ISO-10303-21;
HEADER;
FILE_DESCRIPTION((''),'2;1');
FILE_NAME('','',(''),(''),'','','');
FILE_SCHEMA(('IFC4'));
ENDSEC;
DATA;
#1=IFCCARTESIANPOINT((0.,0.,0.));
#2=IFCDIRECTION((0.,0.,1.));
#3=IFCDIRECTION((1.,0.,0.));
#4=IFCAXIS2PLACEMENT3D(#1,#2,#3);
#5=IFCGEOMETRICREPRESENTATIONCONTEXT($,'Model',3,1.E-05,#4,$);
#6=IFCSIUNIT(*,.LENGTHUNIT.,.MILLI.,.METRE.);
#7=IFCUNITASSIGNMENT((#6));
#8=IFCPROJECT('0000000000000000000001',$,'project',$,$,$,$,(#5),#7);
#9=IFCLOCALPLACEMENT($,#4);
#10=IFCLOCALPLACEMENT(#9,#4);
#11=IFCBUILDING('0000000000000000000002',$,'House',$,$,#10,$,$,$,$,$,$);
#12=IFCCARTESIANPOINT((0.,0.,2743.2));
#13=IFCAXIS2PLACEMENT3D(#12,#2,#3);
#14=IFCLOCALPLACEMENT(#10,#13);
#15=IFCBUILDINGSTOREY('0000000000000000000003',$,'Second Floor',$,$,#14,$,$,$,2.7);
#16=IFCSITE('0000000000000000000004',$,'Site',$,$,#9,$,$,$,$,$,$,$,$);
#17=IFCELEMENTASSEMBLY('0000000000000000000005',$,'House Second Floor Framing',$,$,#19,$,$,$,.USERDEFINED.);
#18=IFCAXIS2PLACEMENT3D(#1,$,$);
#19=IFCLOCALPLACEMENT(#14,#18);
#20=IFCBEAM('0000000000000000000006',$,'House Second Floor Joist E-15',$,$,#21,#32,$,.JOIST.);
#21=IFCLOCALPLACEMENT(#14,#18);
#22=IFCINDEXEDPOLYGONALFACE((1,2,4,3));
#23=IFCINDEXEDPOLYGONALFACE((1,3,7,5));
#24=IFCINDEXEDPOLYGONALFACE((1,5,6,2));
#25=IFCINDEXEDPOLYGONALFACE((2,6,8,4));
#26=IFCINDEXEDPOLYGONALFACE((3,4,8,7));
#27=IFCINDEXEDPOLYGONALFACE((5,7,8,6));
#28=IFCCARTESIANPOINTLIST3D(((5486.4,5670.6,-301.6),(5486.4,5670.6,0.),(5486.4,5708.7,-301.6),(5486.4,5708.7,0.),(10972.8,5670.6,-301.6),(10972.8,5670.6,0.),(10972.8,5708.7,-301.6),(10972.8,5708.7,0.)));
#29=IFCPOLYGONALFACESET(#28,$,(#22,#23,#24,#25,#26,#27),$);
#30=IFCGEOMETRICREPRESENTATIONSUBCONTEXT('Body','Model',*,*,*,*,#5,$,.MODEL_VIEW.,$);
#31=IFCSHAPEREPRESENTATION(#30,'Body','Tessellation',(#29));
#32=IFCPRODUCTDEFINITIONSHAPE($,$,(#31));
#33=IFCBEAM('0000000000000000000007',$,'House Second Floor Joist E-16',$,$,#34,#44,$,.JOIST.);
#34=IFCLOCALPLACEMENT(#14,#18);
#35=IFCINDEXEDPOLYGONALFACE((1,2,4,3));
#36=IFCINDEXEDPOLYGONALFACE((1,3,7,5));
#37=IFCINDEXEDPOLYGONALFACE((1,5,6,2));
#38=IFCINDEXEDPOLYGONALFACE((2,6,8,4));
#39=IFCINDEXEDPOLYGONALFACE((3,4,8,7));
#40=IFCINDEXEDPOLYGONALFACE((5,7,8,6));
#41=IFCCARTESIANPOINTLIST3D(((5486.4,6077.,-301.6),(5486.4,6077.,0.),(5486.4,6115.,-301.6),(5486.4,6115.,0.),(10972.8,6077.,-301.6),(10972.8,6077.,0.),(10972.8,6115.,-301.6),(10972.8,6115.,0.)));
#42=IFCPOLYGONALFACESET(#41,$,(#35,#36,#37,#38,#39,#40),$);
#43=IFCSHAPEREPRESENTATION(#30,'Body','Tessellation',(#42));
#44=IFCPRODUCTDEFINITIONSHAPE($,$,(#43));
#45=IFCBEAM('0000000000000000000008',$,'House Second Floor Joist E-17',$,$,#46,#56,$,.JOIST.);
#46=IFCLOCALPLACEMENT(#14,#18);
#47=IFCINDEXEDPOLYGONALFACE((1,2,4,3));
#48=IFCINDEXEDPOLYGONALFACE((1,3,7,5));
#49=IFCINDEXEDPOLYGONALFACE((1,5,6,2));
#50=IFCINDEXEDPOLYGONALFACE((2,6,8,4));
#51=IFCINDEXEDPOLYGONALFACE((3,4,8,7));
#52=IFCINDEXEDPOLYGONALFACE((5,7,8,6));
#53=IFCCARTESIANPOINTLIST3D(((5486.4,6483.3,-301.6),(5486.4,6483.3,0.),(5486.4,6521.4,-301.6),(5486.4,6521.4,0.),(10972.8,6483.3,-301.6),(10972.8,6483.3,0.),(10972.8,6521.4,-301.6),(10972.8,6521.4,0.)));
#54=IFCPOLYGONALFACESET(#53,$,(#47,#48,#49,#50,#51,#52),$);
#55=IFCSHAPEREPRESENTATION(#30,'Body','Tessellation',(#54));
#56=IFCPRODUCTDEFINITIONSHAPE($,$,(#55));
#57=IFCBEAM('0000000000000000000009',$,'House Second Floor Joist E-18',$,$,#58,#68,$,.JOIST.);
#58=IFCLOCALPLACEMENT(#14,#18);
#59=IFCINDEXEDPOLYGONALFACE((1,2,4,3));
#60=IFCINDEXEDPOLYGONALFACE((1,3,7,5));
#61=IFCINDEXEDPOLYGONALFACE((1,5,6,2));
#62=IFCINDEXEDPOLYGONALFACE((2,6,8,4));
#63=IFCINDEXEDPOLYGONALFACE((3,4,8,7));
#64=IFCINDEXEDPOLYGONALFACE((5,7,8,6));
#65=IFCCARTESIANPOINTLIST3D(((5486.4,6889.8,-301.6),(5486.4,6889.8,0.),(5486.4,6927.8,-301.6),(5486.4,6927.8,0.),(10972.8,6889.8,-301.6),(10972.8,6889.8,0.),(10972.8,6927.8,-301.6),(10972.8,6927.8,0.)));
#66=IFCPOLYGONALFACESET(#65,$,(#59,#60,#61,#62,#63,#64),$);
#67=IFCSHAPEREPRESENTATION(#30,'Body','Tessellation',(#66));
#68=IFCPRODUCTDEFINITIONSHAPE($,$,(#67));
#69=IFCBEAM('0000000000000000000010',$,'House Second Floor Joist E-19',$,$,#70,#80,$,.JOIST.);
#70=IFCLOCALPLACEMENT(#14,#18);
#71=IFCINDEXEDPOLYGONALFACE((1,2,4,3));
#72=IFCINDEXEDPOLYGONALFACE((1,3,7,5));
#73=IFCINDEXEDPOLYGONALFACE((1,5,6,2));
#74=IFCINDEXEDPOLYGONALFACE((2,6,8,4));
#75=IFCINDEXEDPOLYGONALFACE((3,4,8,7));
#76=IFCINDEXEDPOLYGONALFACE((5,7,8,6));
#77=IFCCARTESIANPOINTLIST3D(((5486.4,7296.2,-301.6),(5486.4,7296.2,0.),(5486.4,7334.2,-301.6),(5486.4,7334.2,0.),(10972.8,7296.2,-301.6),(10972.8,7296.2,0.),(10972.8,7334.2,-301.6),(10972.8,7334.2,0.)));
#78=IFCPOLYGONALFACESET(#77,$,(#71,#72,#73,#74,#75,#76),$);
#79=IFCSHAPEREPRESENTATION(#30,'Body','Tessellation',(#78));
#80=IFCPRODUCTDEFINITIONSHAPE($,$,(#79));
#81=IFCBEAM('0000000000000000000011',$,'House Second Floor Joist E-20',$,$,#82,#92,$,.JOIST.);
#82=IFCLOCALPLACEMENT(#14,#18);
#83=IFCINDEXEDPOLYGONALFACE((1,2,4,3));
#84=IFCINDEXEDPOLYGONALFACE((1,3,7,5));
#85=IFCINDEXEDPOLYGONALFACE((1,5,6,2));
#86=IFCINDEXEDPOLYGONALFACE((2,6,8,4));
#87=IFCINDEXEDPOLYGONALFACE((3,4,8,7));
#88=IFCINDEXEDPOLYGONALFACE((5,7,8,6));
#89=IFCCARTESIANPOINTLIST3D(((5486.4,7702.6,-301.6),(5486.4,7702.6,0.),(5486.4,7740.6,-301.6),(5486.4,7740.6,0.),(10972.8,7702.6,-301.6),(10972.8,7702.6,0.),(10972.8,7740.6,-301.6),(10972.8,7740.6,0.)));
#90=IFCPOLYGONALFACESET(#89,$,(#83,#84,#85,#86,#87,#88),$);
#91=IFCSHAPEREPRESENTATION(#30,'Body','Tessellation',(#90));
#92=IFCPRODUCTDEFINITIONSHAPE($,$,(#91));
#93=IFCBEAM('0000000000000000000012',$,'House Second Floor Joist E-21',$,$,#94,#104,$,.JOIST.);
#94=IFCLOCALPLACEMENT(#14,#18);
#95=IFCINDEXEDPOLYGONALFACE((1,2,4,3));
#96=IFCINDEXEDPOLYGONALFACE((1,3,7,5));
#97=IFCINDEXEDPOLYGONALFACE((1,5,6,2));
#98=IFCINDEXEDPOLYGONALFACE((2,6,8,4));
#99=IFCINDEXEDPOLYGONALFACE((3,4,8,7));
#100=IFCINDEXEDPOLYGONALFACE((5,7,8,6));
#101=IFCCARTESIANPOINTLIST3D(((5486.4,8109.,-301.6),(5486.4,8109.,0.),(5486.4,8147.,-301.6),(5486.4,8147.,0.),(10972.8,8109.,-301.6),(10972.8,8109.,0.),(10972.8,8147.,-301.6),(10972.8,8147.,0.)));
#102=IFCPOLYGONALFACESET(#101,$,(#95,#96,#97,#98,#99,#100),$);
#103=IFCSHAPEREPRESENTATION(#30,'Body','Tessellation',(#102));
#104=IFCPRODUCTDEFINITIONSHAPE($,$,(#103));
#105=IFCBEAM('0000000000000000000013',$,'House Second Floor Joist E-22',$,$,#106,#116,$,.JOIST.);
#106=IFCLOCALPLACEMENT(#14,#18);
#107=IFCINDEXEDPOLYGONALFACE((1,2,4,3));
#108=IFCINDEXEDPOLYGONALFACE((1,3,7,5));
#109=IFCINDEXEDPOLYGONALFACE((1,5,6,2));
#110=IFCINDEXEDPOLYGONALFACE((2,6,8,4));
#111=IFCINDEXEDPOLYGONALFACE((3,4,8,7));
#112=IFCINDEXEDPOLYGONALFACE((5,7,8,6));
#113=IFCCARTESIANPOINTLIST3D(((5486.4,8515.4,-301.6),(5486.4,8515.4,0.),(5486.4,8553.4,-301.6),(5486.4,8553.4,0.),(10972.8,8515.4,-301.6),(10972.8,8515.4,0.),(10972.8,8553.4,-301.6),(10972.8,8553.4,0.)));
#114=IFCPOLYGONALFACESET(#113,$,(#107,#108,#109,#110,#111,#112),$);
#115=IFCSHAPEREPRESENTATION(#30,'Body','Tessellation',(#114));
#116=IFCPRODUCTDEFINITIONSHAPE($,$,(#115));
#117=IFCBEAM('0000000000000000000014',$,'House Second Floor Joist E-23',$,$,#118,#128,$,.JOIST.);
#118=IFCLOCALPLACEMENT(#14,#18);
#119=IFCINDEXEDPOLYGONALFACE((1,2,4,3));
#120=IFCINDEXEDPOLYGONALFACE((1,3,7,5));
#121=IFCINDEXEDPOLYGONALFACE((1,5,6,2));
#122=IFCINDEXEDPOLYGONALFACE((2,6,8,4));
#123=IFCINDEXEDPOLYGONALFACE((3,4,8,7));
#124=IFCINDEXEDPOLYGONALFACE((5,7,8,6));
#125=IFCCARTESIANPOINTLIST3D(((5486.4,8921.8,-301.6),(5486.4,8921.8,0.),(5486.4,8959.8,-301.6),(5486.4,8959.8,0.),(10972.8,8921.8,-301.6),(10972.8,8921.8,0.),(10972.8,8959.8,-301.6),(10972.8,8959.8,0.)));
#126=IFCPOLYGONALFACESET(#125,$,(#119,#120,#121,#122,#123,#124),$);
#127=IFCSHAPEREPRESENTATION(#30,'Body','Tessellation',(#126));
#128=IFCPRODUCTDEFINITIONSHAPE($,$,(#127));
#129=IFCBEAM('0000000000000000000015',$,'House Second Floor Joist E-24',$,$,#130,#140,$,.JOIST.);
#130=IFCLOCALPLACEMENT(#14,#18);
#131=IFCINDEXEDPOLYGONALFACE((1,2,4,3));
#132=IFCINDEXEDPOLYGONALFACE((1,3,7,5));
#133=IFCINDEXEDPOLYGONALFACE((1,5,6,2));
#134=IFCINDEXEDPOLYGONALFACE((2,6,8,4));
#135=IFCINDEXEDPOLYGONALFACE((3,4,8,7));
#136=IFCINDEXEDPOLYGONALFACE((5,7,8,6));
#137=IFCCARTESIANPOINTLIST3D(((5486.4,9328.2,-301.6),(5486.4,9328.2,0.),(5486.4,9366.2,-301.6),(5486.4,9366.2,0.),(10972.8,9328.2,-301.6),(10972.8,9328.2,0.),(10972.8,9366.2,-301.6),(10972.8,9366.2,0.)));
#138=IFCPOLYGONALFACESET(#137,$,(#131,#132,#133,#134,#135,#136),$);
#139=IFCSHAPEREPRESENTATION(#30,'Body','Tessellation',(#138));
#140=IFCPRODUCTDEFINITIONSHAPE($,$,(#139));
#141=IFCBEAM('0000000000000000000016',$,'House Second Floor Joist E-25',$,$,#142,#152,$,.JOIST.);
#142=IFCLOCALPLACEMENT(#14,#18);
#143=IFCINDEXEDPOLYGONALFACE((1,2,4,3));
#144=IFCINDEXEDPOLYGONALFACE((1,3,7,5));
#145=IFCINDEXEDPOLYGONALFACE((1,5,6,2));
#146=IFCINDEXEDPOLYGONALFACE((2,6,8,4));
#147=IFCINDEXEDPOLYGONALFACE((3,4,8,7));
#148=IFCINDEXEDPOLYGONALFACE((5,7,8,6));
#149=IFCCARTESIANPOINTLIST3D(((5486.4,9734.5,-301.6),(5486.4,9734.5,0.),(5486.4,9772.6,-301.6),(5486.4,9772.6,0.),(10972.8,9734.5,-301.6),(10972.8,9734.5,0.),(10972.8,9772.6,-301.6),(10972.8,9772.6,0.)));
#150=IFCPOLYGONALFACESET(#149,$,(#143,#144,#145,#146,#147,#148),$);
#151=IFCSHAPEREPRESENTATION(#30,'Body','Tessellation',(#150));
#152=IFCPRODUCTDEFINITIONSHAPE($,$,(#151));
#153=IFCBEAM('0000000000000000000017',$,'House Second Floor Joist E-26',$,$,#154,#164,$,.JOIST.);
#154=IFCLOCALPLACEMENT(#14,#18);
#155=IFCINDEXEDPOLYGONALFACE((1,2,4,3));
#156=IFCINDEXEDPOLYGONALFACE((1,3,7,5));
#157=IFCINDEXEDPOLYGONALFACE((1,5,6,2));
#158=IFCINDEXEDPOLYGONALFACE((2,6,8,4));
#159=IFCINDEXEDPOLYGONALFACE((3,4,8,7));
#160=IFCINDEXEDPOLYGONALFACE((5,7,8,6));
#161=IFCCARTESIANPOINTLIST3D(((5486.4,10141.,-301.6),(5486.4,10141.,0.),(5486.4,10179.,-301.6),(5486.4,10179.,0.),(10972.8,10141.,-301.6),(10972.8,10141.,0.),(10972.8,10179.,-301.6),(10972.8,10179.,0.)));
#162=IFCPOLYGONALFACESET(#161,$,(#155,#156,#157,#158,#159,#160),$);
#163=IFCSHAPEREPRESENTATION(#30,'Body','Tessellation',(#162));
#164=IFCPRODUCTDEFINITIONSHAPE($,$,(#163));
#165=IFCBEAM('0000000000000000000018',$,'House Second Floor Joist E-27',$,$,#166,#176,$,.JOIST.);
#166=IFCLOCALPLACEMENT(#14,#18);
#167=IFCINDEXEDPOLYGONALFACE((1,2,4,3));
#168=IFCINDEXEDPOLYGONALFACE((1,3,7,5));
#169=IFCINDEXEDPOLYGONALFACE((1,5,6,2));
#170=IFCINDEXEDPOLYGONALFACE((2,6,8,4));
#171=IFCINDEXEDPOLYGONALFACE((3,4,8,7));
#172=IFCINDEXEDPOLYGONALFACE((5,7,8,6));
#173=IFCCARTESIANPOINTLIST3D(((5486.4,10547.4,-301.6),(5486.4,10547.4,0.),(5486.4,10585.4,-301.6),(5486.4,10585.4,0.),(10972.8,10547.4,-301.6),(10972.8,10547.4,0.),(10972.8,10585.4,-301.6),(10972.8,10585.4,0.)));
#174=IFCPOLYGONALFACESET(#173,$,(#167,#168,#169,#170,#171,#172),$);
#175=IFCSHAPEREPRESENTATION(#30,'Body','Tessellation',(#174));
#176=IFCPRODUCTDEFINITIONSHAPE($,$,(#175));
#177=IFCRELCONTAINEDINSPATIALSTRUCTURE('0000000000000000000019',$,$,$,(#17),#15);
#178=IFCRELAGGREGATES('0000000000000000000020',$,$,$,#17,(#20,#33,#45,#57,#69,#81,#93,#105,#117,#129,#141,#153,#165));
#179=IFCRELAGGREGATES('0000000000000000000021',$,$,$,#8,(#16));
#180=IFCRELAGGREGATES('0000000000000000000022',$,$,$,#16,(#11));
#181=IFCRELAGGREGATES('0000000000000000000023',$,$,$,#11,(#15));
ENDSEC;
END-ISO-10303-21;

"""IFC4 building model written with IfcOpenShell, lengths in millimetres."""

from ifc_helpers import new_model, si_unit, frame, origin_with_axes, origin_2d, place, context, subcontext, project, spatial, rectangle, extrude, element, aggregate, save


model = new_model("IFC4")

# Units and contexts
model_context = context("Model", 3, precision=1e-05, world=origin_with_axes())
body_context = subcontext(model_context, "Body", "Model", "MODEL_VIEW")
ifc_project = project(units=[si_unit("LENGTHUNIT", "METRE", prefix="MILLI")], contexts=[model_context])

# Site, building, storey
site_placement = place(None, origin_with_axes())
site = spatial("IfcSite", under=ifc_project, at=site_placement, Name="Site")
building_placement = place(site_placement, origin_with_axes())
building = spatial("IfcBuilding", under=site, at=building_placement, Name="House")
storey_placement = place(building_placement, frame((0.0, 0.0, 2743.2), z_axis=(0.0, 0.0, 1.0), x_axis=(1.0, 0.0, 0.0)))
storey = spatial("IfcBuildingStorey", under=building, at=storey_placement, Name="Second Floor", Elevation=2.7)

# Element assembly, beams
assembly_1_placement = place(storey_placement, frame((0.0, 0.0, -2743.2), z_axis=(0.0, 0.0, 1.0), x_axis=(1.0, 0.0, 0.0)))
assembly_1 = element("IfcElementAssembly", 1, at=assembly_1_placement, inside=storey, Name="House Second Floor Framing", PredefinedType="USERDEFINED")
beam_1_placement = place(assembly_1_placement, frame((5486.4, 5689.6, 2592.4), z_axis=(1.0, 0.0, 0.0), x_axis=(0.0, 1.0, 0.0)))
beam_1 = element("IfcBeam", 2, at=beam_1_placement, Name="House Second Floor Joist E-15", PredefinedType="JOIST", context=body_context, shape_type="SweptSolid", body=[
    extrude(rectangle(XDim=38.1, YDim=301.6, at=origin_2d()), origin_with_axes(), (0.0, 0.0, 1.0), 5486.4),
])
beam_2_placement = place(assembly_1_placement, frame((5486.4, 6096.0, 2592.4), z_axis=(1.0, 0.0, 0.0), x_axis=(0.0, 1.0, 0.0)))
beam_2 = element("IfcBeam", 3, at=beam_2_placement, Name="House Second Floor Joist E-16", PredefinedType="JOIST", context=body_context, shape_type="SweptSolid", body=[
    extrude(rectangle(XDim=38.1, YDim=301.6, at=origin_2d()), origin_with_axes(), (0.0, 0.0, 1.0), 5486.4),
])
beam_3_placement = place(assembly_1_placement, frame((5486.4, 6502.4, 2592.4), z_axis=(1.0, 0.0, 0.0), x_axis=(0.0, 1.0, 0.0)))
beam_3 = element("IfcBeam", 4, at=beam_3_placement, Name="House Second Floor Joist E-17", PredefinedType="JOIST", context=body_context, shape_type="SweptSolid", body=[
    extrude(rectangle(XDim=38.1, YDim=301.6, at=origin_2d()), origin_with_axes(), (0.0, 0.0, 1.0), 5486.4),
])
beam_4_placement = place(assembly_1_placement, frame((5486.4, 6908.8, 2592.4), z_axis=(1.0, 0.0, 0.0), x_axis=(0.0, 1.0, 0.0)))
beam_4 = element("IfcBeam", 5, at=beam_4_placement, Name="House Second Floor Joist E-18", PredefinedType="JOIST", context=body_context, shape_type="SweptSolid", body=[
    extrude(rectangle(XDim=38.1, YDim=301.6, at=origin_2d()), origin_with_axes(), (0.0, 0.0, 1.0), 5486.4),
])
beam_5_placement = place(assembly_1_placement, frame((5486.4, 7315.2, 2592.4), z_axis=(1.0, 0.0, 0.0), x_axis=(0.0, 1.0, 0.0)))
beam_5 = element("IfcBeam", 6, at=beam_5_placement, Name="House Second Floor Joist E-19", PredefinedType="JOIST", context=body_context, shape_type="SweptSolid", body=[
    extrude(rectangle(XDim=38.1, YDim=301.6, at=origin_2d()), origin_with_axes(), (0.0, 0.0, 1.0), 5486.4),
])
beam_6_placement = place(assembly_1_placement, frame((5486.4, 7721.6, 2592.4), z_axis=(1.0, 0.0, 0.0), x_axis=(0.0, 1.0, 0.0)))
beam_6 = element("IfcBeam", 7, at=beam_6_placement, Name="House Second Floor Joist E-20", PredefinedType="JOIST", context=body_context, shape_type="SweptSolid", body=[
    extrude(rectangle(XDim=38.1, YDim=301.6, at=origin_2d()), origin_with_axes(), (0.0, 0.0, 1.0), 5486.4),
])
beam_7_placement = place(assembly_1_placement, frame((5486.4, 8128.0, 2592.4), z_axis=(1.0, 0.0, 0.0), x_axis=(0.0, 1.0, 0.0)))
beam_7 = element("IfcBeam", 8, at=beam_7_placement, Name="House Second Floor Joist E-21", PredefinedType="JOIST", context=body_context, shape_type="SweptSolid", body=[
    extrude(rectangle(XDim=38.1, YDim=301.6, at=origin_2d()), origin_with_axes(), (0.0, 0.0, 1.0), 5486.4),
])
beam_8_placement = place(assembly_1_placement, frame((5486.4, 8534.4, 2592.4), z_axis=(1.0, 0.0, 0.0), x_axis=(0.0, 1.0, 0.0)))
beam_8 = element("IfcBeam", 9, at=beam_8_placement, Name="House Second Floor Joist E-22", PredefinedType="JOIST", context=body_context, shape_type="SweptSolid", body=[
    extrude(rectangle(XDim=38.1, YDim=301.6, at=origin_2d()), origin_with_axes(), (0.0, 0.0, 1.0), 5486.4),
])
beam_9_placement = place(assembly_1_placement, frame((5486.4, 8940.8, 2592.4), z_axis=(1.0, 0.0, 0.0), x_axis=(0.0, 1.0, 0.0)))
beam_9 = element("IfcBeam", 10, at=beam_9_placement, Name="House Second Floor Joist E-23", PredefinedType="JOIST", context=body_context, shape_type="SweptSolid", body=[
    extrude(rectangle(XDim=38.1, YDim=301.6, at=origin_2d()), origin_with_axes(), (0.0, 0.0, 1.0), 5486.4),
])
beam_10_placement = place(assembly_1_placement, frame((5486.4, 9347.2, 2592.4), z_axis=(1.0, 0.0, 0.0), x_axis=(0.0, 1.0, 0.0)))
beam_10 = element("IfcBeam", 11, at=beam_10_placement, Name="House Second Floor Joist E-24", PredefinedType="JOIST", context=body_context, shape_type="SweptSolid", body=[
    extrude(rectangle(XDim=38.1, YDim=301.6, at=origin_2d()), origin_with_axes(), (0.0, 0.0, 1.0), 5486.4),
])
beam_11_placement = place(assembly_1_placement, frame((5486.4, 9753.6, 2592.4), z_axis=(1.0, 0.0, 0.0), x_axis=(0.0, 1.0, 0.0)))
beam_11 = element("IfcBeam", 12, at=beam_11_placement, Name="House Second Floor Joist E-25", PredefinedType="JOIST", context=body_context, shape_type="SweptSolid", body=[
    extrude(rectangle(XDim=38.1, YDim=301.6, at=origin_2d()), origin_with_axes(), (0.0, 0.0, 1.0), 5486.4),
])
beam_12_placement = place(assembly_1_placement, frame((5486.4, 10160.0, 2592.4), z_axis=(1.0, 0.0, 0.0), x_axis=(0.0, 1.0, 0.0)))
beam_12 = element("IfcBeam", 13, at=beam_12_placement, Name="House Second Floor Joist E-26", PredefinedType="JOIST", context=body_context, shape_type="SweptSolid", body=[
    extrude(rectangle(XDim=38.1, YDim=301.6, at=origin_2d()), origin_with_axes(), (0.0, 0.0, 1.0), 5486.4),
])
beam_13_placement = place(assembly_1_placement, frame((5486.4, 10566.4, 2592.4), z_axis=(1.0, 0.0, 0.0), x_axis=(0.0, 1.0, 0.0)))
beam_13 = element("IfcBeam", 14, at=beam_13_placement, Name="House Second Floor Joist E-27", PredefinedType="JOIST", context=body_context, shape_type="SweptSolid", body=[
    extrude(rectangle(XDim=38.1, YDim=301.6, at=origin_2d()), origin_with_axes(), (0.0, 0.0, 1.0), 5486.4),
])
aggregate(assembly_1, [beam_1, beam_2, beam_3, beam_4, beam_5, beam_6, beam_7, beam_8, beam_9, beam_10, beam_11, beam_12, beam_13])

save(model, "model.ifc")
